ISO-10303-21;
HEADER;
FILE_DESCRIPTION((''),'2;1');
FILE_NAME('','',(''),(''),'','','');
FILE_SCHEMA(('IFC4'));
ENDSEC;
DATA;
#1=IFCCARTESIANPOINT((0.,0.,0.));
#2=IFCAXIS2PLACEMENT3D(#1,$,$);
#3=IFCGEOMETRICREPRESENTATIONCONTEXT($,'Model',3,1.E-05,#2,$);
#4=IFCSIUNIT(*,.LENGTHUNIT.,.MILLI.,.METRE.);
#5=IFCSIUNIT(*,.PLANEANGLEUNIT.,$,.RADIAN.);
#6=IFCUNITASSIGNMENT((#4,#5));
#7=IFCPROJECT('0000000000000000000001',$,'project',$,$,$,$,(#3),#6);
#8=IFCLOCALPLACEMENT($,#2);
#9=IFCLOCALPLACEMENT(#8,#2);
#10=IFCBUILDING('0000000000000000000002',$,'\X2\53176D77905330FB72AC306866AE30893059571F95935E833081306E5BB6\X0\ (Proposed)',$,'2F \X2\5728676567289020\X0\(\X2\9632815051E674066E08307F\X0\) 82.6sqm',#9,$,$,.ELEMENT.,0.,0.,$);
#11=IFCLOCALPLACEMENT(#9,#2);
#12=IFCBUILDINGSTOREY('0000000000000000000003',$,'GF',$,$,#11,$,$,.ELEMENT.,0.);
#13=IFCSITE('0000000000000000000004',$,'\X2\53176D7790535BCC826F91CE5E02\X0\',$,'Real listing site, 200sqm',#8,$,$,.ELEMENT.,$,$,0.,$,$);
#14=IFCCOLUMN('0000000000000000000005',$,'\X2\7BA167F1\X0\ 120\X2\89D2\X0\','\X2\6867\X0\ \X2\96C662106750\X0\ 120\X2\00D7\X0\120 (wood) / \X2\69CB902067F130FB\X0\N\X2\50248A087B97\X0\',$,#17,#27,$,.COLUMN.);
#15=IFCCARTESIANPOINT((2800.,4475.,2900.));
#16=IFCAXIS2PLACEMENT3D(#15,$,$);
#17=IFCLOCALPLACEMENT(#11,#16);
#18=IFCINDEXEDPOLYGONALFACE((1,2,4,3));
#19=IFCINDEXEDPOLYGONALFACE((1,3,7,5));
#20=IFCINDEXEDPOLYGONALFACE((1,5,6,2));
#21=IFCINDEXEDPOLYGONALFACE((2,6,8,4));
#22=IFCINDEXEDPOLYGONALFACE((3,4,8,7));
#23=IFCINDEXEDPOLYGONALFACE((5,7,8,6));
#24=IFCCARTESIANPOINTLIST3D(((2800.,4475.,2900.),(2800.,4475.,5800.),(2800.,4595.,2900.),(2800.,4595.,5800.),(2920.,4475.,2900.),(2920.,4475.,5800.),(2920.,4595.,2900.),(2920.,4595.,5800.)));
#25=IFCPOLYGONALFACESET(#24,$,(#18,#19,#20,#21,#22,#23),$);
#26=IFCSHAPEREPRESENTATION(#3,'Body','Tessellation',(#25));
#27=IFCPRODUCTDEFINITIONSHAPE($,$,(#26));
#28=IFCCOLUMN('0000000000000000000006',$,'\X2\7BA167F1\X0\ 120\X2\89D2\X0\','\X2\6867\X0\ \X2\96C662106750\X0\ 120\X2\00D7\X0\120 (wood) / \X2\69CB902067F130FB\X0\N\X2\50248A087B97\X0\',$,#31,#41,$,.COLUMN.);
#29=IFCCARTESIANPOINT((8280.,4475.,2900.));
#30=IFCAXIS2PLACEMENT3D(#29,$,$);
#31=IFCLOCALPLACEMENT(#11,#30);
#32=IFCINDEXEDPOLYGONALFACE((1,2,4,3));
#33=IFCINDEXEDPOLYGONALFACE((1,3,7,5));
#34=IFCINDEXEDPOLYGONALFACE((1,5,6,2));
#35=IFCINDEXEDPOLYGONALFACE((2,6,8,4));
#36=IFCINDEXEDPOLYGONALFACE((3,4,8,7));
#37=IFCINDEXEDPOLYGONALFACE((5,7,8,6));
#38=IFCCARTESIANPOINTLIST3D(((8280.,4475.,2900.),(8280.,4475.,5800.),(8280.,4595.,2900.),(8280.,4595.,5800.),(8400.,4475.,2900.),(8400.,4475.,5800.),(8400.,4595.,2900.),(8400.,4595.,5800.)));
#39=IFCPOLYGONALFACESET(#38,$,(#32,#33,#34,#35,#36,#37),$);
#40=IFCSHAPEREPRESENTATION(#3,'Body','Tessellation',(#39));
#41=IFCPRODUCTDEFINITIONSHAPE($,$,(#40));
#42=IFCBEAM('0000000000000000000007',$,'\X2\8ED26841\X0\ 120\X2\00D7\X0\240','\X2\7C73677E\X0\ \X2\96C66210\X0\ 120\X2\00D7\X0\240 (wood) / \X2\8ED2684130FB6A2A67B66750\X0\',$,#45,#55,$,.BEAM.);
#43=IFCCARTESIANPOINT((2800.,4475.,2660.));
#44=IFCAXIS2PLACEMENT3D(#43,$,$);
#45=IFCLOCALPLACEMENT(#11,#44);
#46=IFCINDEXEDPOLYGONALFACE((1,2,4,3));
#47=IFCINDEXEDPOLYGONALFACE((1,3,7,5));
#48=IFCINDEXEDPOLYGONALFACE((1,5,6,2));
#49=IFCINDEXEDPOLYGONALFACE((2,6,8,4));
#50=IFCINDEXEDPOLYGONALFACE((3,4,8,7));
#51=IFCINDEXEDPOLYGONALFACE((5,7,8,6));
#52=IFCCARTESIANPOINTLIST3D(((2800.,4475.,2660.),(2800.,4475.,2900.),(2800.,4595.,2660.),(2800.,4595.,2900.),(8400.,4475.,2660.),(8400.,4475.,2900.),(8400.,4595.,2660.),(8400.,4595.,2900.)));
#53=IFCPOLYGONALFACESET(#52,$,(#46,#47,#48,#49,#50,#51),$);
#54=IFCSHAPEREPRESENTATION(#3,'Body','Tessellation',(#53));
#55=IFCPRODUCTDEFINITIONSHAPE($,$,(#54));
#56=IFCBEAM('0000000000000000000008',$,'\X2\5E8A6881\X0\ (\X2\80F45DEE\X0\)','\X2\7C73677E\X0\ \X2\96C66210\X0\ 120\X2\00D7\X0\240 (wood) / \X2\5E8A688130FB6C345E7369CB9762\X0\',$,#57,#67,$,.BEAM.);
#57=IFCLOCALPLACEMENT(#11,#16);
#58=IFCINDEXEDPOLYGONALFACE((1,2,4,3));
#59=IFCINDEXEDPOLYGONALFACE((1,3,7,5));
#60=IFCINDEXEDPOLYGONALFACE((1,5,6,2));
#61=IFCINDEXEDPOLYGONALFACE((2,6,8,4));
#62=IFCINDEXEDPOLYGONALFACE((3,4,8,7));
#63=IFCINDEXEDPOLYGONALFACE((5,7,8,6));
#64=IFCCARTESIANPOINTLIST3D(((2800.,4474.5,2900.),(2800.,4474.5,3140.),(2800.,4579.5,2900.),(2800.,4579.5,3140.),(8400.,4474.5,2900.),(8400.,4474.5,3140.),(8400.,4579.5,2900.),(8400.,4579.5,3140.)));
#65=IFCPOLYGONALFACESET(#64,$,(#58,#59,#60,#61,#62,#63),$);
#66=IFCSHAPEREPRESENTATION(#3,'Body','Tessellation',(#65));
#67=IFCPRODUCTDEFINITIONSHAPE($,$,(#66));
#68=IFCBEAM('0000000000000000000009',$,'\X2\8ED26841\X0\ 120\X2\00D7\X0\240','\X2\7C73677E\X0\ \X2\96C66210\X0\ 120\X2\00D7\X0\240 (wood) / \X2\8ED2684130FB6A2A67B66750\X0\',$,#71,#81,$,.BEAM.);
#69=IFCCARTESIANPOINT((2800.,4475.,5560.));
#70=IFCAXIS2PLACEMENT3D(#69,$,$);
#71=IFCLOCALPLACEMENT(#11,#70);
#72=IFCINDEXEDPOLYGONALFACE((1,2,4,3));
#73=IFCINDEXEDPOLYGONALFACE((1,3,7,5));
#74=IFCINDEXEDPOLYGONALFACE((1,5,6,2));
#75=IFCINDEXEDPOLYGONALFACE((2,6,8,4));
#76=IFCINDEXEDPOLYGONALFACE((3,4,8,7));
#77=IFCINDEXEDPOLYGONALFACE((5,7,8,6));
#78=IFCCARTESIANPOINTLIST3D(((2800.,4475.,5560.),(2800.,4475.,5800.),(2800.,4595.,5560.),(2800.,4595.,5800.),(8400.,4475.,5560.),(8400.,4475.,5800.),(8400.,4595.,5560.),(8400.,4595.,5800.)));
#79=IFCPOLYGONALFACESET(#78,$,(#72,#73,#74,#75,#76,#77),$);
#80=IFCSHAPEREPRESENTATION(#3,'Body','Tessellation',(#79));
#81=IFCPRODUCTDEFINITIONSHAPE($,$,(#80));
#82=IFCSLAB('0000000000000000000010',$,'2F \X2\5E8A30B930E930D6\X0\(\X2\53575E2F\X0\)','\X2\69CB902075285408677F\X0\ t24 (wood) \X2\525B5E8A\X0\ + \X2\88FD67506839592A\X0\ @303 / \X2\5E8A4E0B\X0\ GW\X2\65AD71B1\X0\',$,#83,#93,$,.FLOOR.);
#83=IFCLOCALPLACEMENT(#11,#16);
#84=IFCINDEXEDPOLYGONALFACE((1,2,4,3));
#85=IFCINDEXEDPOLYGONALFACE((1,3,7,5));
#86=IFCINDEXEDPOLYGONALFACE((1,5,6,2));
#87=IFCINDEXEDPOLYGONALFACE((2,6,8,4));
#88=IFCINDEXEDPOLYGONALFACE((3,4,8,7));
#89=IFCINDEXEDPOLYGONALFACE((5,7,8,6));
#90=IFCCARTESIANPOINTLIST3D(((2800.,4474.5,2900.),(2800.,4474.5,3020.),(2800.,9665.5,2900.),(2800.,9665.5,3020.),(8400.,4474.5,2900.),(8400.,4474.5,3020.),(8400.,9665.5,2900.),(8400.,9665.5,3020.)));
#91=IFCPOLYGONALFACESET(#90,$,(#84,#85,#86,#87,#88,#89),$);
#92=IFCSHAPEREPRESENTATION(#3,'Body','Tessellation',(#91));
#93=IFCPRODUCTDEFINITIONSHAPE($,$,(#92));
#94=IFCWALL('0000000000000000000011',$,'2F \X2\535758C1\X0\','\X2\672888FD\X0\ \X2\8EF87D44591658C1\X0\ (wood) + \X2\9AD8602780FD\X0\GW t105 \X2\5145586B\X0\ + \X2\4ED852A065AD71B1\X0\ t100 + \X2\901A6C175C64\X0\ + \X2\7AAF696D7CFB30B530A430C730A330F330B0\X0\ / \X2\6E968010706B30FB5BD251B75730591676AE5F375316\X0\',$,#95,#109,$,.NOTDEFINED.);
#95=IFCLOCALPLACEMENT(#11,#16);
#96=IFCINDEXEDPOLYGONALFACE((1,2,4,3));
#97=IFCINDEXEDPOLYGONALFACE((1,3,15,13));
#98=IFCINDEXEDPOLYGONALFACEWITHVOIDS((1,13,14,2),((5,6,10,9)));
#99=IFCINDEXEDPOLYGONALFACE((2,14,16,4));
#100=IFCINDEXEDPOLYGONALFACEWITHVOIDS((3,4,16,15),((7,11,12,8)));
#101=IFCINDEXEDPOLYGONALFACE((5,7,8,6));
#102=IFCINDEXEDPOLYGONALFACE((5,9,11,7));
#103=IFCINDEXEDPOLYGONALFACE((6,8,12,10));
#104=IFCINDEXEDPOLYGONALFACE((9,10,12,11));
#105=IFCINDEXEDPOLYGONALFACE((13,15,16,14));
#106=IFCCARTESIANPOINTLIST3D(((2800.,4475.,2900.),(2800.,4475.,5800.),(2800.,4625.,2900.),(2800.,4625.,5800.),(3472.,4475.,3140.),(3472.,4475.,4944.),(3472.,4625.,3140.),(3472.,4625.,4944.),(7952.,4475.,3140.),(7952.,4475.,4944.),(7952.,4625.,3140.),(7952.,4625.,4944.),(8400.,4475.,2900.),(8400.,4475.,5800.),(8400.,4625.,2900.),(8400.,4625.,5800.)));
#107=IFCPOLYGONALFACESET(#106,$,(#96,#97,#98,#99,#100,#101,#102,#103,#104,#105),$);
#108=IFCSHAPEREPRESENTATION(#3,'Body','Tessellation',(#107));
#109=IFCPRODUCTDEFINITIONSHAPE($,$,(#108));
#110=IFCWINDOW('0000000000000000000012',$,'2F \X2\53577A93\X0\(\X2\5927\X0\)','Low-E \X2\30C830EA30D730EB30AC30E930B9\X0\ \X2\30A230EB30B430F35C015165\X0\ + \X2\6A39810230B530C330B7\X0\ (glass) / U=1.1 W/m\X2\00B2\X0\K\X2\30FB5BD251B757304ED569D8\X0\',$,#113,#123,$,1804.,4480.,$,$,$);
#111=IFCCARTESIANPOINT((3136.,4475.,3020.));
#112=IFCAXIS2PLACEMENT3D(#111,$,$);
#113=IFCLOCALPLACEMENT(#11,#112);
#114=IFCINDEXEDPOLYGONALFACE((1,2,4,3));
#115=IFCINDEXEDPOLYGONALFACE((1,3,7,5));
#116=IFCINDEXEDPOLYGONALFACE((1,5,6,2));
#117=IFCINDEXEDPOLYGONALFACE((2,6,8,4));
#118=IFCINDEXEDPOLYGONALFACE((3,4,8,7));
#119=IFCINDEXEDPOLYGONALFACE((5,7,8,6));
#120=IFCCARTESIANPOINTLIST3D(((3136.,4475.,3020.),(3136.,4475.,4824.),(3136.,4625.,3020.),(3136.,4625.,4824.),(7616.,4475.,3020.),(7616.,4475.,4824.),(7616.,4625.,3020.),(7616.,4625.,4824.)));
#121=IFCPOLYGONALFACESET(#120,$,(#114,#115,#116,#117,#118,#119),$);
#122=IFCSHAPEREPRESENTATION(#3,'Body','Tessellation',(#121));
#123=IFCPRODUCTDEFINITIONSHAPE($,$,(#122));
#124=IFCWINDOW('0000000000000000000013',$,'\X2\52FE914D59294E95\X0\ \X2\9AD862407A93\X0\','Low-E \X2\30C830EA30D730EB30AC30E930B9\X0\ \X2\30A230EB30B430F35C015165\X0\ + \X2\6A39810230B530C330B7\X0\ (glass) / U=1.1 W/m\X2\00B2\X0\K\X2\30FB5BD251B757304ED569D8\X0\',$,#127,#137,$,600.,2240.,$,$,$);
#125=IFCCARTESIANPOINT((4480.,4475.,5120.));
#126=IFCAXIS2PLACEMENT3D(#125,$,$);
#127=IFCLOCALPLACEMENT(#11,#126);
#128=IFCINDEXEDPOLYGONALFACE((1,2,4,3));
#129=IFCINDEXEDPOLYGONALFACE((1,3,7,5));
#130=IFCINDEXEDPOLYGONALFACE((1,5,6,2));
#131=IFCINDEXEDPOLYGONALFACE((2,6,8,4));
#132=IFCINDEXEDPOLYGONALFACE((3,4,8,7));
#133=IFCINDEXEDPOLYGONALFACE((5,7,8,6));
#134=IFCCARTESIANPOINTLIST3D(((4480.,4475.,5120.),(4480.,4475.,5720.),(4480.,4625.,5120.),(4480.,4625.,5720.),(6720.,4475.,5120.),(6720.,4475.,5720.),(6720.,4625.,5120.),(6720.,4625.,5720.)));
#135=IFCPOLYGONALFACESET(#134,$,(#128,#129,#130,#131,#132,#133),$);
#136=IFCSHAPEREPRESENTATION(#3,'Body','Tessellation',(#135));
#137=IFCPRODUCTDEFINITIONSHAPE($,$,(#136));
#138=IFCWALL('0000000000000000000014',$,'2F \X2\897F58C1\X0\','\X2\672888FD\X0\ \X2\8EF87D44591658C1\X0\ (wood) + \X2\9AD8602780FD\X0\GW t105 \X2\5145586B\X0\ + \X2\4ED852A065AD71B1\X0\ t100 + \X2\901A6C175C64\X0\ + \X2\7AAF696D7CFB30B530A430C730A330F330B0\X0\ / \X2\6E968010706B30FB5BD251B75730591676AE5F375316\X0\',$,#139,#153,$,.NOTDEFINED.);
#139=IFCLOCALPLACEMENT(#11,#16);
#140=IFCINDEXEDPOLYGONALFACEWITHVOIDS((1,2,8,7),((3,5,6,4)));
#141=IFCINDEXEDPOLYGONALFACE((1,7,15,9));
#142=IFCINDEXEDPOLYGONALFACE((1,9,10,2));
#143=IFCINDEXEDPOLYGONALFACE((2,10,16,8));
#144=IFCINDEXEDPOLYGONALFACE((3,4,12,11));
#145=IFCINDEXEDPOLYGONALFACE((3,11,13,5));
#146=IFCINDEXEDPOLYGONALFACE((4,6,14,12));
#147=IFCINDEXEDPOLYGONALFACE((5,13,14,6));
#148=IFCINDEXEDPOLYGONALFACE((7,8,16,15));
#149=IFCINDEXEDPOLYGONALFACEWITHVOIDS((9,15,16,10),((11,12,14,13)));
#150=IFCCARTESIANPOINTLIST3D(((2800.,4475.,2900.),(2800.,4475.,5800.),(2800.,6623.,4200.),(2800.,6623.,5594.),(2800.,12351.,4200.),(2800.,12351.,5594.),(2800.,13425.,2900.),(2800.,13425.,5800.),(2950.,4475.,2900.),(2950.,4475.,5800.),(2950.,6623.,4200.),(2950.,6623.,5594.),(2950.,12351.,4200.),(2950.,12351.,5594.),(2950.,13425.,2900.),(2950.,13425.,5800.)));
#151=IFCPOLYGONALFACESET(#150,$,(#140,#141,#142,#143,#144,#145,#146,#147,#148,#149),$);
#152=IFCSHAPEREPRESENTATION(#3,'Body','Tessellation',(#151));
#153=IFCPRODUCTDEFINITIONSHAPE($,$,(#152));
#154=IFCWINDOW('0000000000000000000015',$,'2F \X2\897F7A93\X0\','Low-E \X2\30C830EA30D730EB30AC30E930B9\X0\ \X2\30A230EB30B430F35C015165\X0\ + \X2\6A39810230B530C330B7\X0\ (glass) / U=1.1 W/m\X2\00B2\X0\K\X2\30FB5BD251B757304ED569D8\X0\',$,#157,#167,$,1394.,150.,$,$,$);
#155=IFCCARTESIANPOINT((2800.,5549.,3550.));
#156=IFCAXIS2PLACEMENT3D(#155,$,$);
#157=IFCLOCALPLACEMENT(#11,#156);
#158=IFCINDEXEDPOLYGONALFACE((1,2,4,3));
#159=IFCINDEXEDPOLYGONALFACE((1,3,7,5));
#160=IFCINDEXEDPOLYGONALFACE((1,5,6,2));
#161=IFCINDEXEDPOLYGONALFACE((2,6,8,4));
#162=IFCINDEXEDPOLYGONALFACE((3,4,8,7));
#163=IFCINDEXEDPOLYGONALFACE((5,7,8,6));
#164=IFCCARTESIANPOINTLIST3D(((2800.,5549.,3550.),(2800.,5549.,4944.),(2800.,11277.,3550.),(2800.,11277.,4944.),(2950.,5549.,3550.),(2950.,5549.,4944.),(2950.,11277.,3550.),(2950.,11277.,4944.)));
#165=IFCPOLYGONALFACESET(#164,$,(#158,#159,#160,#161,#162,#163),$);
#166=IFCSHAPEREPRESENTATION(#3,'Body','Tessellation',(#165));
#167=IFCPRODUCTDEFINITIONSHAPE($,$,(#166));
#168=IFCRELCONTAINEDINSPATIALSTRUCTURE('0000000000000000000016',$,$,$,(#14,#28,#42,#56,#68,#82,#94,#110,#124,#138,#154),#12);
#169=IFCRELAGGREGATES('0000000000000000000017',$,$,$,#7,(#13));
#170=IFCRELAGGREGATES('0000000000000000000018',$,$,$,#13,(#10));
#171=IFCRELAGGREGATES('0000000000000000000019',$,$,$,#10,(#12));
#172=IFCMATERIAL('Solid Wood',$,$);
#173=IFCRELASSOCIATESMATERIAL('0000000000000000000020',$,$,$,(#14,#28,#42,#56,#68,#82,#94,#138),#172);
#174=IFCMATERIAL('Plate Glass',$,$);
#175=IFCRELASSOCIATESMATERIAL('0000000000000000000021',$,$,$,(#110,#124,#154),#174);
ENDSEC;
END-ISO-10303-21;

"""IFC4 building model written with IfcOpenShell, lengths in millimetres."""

from ifc_helpers import new_model, si_unit, frame, frame_2d, origin, place, context, project, spatial, rectangle, extrude, material, element, fill, save


model = new_model("IFC4")

# Units and contexts
model_context = context("Model", 3, precision=1e-05, world=origin())
ifc_project = project(units=[si_unit("LENGTHUNIT", "METRE", prefix="MILLI"), si_unit("PLANEANGLEUNIT", "RADIAN")], contexts=[model_context])

# Site, building, storey
site_placement = place(None, origin())
site = spatial("IfcSite", under=ifc_project, at=site_placement, Name="北海道富良野市", ObjectType="Real listing site, 200sqm", CompositionType="ELEMENT", RefElevation=0.0)
building_placement = place(site_placement, origin())
building = spatial("IfcBuilding", under=site, at=building_placement, Name="北海道・犬と暮らす土間広めの家 (Proposed)", ObjectType="2F 在来木造(防腐処理済み) 82.6sqm", CompositionType="ELEMENT", ElevationOfRefHeight=0.0, ElevationOfTerrain=0.0)
storey_placement = place(building_placement, origin())
storey = spatial("IfcBuildingStorey", under=building, at=storey_placement, Name="GF", CompositionType="ELEMENT", Elevation=0.0)

# Columns
ifc_material_1 = material(Name="Solid Wood")
column_1_placement = place(storey_placement, frame((2800.0, 4475.0, 2900.0)))
element("IfcColumn", 1, at=column_1_placement, inside=storey, material=ifc_material_1, Name="管柱 120角", Description="桧 集成材 120×120 (wood) / 構造柱・N値計算", PredefinedType="COLUMN", context=model_context, shape_type="SweptSolid", body=[
    extrude(rectangle(XDim=120.0, YDim=120.0, at=frame_2d((60.0, 60.0))), frame((2800.0, 4475.0, 2900.0)), (0.0, 0.0, 1.0), 2900.0),
])
column_2_placement = place(storey_placement, frame((8280.0, 4475.0, 2900.0)))
element("IfcColumn", 2, at=column_2_placement, inside=storey, material=ifc_material_1, Name="管柱 120角", Description="桧 集成材 120×120 (wood) / 構造柱・N値計算", PredefinedType="COLUMN", context=model_context, shape_type="SweptSolid", body=[
    extrude(rectangle(XDim=120.0, YDim=120.0, at=frame_2d((60.0, 60.0))), frame((8280.0, 4475.0, 2900.0)), (0.0, 0.0, 1.0), 2900.0),
])

# Beams
beam_1_placement = place(storey_placement, frame((2800.0, 4475.0, 2660.0)))
element("IfcBeam", 3, at=beam_1_placement, inside=storey, material=ifc_material_1, Name="軒桁 120×240", Description="米松 集成 120×240 (wood) / 軒桁・横架材", PredefinedType="BEAM", context=model_context, shape_type="SweptSolid", body=[
    extrude(rectangle(XDim=5600.0, YDim=120.0, at=frame_2d((2800.0, 60.0))), frame((2800.0, 4475.0, 2660.0)), (0.0, 0.0, 1.0), 240.0),
])
beam_2_placement = place(storey_placement, frame((2800.0, 4475.0, 2900.0)))
element("IfcBeam", 4, at=beam_2_placement, inside=storey, material=ifc_material_1, Name="床梁 (胴差)", Description="米松 集成 120×240 (wood) / 床梁・水平構面", PredefinedType="BEAM", context=model_context, shape_type="SweptSolid", body=[
    extrude(rectangle(XDim=5600.0, YDim=105.0, at=frame_2d((2800.0, 52.0))), frame((2800.0, 4475.0, 2900.0)), (0.0, 0.0, 1.0), 240.0),
])
beam_3_placement = place(storey_placement, frame((2800.0, 4475.0, 5560.0)))
element("IfcBeam", 5, at=beam_3_placement, inside=storey, material=ifc_material_1, Name="軒桁 120×240", Description="米松 集成 120×240 (wood) / 軒桁・横架材", PredefinedType="BEAM", context=model_context, shape_type="SweptSolid", body=[
    extrude(rectangle(XDim=5600.0, YDim=120.0, at=frame_2d((2800.0, 60.0))), frame((2800.0, 4475.0, 5560.0)), (0.0, 0.0, 1.0), 240.0),
])

# Slab
slab_placement = place(storey_placement, frame((2800.0, 4475.0, 2900.0)))
element("IfcSlab", 6, at=slab_placement, inside=storey, material=ifc_material_1, Name="2F 床スラブ(南帯)", Description="構造用合板 t24 (wood) 剛床 + 製材根太 @303 / 床下 GW断熱", PredefinedType="FLOOR", context=model_context, shape_type="SweptSolid", body=[
    extrude(rectangle(XDim=5600.0, YDim=5191.0, at=frame_2d((2800.0, 2595.0))), frame((2800.0, 4475.0, 2900.0)), (0.0, 0.0, 1.0), 120.0),
])

# Wall, openings, windows
wall_1_placement = place(storey_placement, frame((2800.0, 4475.0, 2900.0)))
wall_1 = element("IfcWall", 7, at=wall_1_placement, inside=storey, material=ifc_material_1, Name="2F 南壁", Description="木製 軸組外壁 (wood) + 高性能GW t105 充填 + 付加断熱 t100 + 通気層 + 窯業系サイディング / 準耐火・寒冷地外皮強化", PredefinedType="NOTDEFINED", context=model_context, shape_type="SweptSolid", body=[
    extrude(rectangle(XDim=5600.0, YDim=150.0, at=frame_2d((2800.0, 75.0))), frame((2800.0, 4475.0, 2900.0)), (0.0, 0.0, 1.0), 2900.0),
])
opening_1_placement = place(storey_placement, frame((3136.0, 4475.0, 3020.0)))
opening_1 = element("IfcOpeningElement", 8, at=opening_1_placement, cuts=wall_1, PredefinedType="NOTDEFINED", context=model_context, shape_type="SweptSolid", body=[
    extrude(rectangle(XDim=4480.0, YDim=150.0, at=frame_2d((2240.0, 75.0))), frame((3136.0, 4475.0, 3020.0)), (0.0, 0.0, 1.0), 1804.0),
])
opening_2_placement = place(storey_placement, frame((4480.0, 4475.0, 5120.0)))
opening_2 = element("IfcOpeningElement", 9, at=opening_2_placement, cuts=wall_1, PredefinedType="NOTDEFINED", context=model_context, shape_type="SweptSolid", body=[
    extrude(rectangle(XDim=2240.0, YDim=150.0, at=frame_2d((1120.0, 75.0))), frame((4480.0, 4475.0, 5120.0)), (0.0, 0.0, 1.0), 600.0),
])
ifc_material_2 = material(Name="Plate Glass")
window_1_placement = place(storey_placement, frame((3136.0, 4475.0, 3020.0)))
window_1 = element("IfcWindow", 10, at=window_1_placement, inside=storey, material=ifc_material_2, Name="2F 南窓(大)", Description="Low-E トリプルガラス アルゴン封入 + 樹脂サッシ (glass) / U=1.1 W/m²K・寒冷地仕様", OverallHeight=1804.0, OverallWidth=4480.0, context=model_context, shape_type="SweptSolid", body=[
    extrude(rectangle(XDim=4480.0, YDim=150.0, at=frame_2d((2240.0, 75.0))), frame((3136.0, 4475.0, 3020.0)), (0.0, 0.0, 1.0), 1804.0),
])
fill(opening_1, window_1)
window_2_placement = place(storey_placement, frame((4480.0, 4475.0, 5120.0)))
window_2 = element("IfcWindow", 11, at=window_2_placement, inside=storey, material=ifc_material_2, Name="勾配天井 高所窓", Description="Low-E トリプルガラス アルゴン封入 + 樹脂サッシ (glass) / U=1.1 W/m²K・寒冷地仕様", OverallHeight=600.0, OverallWidth=2240.0, context=model_context, shape_type="SweptSolid", body=[
    extrude(rectangle(XDim=2240.0, YDim=150.0, at=frame_2d((1120.0, 75.0))), frame((4480.0, 4475.0, 5120.0)), (0.0, 0.0, 1.0), 600.0),
])
fill(opening_2, window_2)

# Wall, opening, window
wall_2_placement = place(storey_placement, frame((2800.0, 4475.0, 2900.0)))
wall_2 = element("IfcWall", 12, at=wall_2_placement, inside=storey, material=ifc_material_1, Name="2F 西壁", Description="木製 軸組外壁 (wood) + 高性能GW t105 充填 + 付加断熱 t100 + 通気層 + 窯業系サイディング / 準耐火・寒冷地外皮強化", PredefinedType="NOTDEFINED", context=model_context, shape_type="SweptSolid", body=[
    extrude(rectangle(XDim=150.0, YDim=8950.0, at=frame_2d((75.0, 4475.0))), frame((2800.0, 4475.0, 2900.0)), (0.0, 0.0, 1.0), 2900.0),
])
opening_3_placement = place(storey_placement, frame((2800.0, 5549.0, 3550.0)))
opening_3 = element("IfcOpeningElement", 13, at=opening_3_placement, cuts=wall_2, PredefinedType="NOTDEFINED", context=model_context, shape_type="SweptSolid", body=[
    extrude(rectangle(XDim=150.0, YDim=5728.0, at=frame_2d((75.0, 2864.0))), frame((2800.0, 5549.0, 3550.0)), (0.0, 0.0, 1.0), 1394.0),
])
window_3_placement = place(storey_placement, frame((2800.0, 5549.0, 3550.0)))
window_3 = element("IfcWindow", 14, at=window_3_placement, inside=storey, material=ifc_material_2, Name="2F 西窓", Description="Low-E トリプルガラス アルゴン封入 + 樹脂サッシ (glass) / U=1.1 W/m²K・寒冷地仕様", OverallHeight=1394.0, OverallWidth=150.0, context=model_context, shape_type="SweptSolid", body=[
    extrude(rectangle(XDim=150.0, YDim=5728.0, at=frame_2d((75.0, 2864.0))), frame((2800.0, 5549.0, 3550.0)), (0.0, 0.0, 1.0), 1394.0),
])
fill(opening_3, window_3)

save(model, "model.ifc")
